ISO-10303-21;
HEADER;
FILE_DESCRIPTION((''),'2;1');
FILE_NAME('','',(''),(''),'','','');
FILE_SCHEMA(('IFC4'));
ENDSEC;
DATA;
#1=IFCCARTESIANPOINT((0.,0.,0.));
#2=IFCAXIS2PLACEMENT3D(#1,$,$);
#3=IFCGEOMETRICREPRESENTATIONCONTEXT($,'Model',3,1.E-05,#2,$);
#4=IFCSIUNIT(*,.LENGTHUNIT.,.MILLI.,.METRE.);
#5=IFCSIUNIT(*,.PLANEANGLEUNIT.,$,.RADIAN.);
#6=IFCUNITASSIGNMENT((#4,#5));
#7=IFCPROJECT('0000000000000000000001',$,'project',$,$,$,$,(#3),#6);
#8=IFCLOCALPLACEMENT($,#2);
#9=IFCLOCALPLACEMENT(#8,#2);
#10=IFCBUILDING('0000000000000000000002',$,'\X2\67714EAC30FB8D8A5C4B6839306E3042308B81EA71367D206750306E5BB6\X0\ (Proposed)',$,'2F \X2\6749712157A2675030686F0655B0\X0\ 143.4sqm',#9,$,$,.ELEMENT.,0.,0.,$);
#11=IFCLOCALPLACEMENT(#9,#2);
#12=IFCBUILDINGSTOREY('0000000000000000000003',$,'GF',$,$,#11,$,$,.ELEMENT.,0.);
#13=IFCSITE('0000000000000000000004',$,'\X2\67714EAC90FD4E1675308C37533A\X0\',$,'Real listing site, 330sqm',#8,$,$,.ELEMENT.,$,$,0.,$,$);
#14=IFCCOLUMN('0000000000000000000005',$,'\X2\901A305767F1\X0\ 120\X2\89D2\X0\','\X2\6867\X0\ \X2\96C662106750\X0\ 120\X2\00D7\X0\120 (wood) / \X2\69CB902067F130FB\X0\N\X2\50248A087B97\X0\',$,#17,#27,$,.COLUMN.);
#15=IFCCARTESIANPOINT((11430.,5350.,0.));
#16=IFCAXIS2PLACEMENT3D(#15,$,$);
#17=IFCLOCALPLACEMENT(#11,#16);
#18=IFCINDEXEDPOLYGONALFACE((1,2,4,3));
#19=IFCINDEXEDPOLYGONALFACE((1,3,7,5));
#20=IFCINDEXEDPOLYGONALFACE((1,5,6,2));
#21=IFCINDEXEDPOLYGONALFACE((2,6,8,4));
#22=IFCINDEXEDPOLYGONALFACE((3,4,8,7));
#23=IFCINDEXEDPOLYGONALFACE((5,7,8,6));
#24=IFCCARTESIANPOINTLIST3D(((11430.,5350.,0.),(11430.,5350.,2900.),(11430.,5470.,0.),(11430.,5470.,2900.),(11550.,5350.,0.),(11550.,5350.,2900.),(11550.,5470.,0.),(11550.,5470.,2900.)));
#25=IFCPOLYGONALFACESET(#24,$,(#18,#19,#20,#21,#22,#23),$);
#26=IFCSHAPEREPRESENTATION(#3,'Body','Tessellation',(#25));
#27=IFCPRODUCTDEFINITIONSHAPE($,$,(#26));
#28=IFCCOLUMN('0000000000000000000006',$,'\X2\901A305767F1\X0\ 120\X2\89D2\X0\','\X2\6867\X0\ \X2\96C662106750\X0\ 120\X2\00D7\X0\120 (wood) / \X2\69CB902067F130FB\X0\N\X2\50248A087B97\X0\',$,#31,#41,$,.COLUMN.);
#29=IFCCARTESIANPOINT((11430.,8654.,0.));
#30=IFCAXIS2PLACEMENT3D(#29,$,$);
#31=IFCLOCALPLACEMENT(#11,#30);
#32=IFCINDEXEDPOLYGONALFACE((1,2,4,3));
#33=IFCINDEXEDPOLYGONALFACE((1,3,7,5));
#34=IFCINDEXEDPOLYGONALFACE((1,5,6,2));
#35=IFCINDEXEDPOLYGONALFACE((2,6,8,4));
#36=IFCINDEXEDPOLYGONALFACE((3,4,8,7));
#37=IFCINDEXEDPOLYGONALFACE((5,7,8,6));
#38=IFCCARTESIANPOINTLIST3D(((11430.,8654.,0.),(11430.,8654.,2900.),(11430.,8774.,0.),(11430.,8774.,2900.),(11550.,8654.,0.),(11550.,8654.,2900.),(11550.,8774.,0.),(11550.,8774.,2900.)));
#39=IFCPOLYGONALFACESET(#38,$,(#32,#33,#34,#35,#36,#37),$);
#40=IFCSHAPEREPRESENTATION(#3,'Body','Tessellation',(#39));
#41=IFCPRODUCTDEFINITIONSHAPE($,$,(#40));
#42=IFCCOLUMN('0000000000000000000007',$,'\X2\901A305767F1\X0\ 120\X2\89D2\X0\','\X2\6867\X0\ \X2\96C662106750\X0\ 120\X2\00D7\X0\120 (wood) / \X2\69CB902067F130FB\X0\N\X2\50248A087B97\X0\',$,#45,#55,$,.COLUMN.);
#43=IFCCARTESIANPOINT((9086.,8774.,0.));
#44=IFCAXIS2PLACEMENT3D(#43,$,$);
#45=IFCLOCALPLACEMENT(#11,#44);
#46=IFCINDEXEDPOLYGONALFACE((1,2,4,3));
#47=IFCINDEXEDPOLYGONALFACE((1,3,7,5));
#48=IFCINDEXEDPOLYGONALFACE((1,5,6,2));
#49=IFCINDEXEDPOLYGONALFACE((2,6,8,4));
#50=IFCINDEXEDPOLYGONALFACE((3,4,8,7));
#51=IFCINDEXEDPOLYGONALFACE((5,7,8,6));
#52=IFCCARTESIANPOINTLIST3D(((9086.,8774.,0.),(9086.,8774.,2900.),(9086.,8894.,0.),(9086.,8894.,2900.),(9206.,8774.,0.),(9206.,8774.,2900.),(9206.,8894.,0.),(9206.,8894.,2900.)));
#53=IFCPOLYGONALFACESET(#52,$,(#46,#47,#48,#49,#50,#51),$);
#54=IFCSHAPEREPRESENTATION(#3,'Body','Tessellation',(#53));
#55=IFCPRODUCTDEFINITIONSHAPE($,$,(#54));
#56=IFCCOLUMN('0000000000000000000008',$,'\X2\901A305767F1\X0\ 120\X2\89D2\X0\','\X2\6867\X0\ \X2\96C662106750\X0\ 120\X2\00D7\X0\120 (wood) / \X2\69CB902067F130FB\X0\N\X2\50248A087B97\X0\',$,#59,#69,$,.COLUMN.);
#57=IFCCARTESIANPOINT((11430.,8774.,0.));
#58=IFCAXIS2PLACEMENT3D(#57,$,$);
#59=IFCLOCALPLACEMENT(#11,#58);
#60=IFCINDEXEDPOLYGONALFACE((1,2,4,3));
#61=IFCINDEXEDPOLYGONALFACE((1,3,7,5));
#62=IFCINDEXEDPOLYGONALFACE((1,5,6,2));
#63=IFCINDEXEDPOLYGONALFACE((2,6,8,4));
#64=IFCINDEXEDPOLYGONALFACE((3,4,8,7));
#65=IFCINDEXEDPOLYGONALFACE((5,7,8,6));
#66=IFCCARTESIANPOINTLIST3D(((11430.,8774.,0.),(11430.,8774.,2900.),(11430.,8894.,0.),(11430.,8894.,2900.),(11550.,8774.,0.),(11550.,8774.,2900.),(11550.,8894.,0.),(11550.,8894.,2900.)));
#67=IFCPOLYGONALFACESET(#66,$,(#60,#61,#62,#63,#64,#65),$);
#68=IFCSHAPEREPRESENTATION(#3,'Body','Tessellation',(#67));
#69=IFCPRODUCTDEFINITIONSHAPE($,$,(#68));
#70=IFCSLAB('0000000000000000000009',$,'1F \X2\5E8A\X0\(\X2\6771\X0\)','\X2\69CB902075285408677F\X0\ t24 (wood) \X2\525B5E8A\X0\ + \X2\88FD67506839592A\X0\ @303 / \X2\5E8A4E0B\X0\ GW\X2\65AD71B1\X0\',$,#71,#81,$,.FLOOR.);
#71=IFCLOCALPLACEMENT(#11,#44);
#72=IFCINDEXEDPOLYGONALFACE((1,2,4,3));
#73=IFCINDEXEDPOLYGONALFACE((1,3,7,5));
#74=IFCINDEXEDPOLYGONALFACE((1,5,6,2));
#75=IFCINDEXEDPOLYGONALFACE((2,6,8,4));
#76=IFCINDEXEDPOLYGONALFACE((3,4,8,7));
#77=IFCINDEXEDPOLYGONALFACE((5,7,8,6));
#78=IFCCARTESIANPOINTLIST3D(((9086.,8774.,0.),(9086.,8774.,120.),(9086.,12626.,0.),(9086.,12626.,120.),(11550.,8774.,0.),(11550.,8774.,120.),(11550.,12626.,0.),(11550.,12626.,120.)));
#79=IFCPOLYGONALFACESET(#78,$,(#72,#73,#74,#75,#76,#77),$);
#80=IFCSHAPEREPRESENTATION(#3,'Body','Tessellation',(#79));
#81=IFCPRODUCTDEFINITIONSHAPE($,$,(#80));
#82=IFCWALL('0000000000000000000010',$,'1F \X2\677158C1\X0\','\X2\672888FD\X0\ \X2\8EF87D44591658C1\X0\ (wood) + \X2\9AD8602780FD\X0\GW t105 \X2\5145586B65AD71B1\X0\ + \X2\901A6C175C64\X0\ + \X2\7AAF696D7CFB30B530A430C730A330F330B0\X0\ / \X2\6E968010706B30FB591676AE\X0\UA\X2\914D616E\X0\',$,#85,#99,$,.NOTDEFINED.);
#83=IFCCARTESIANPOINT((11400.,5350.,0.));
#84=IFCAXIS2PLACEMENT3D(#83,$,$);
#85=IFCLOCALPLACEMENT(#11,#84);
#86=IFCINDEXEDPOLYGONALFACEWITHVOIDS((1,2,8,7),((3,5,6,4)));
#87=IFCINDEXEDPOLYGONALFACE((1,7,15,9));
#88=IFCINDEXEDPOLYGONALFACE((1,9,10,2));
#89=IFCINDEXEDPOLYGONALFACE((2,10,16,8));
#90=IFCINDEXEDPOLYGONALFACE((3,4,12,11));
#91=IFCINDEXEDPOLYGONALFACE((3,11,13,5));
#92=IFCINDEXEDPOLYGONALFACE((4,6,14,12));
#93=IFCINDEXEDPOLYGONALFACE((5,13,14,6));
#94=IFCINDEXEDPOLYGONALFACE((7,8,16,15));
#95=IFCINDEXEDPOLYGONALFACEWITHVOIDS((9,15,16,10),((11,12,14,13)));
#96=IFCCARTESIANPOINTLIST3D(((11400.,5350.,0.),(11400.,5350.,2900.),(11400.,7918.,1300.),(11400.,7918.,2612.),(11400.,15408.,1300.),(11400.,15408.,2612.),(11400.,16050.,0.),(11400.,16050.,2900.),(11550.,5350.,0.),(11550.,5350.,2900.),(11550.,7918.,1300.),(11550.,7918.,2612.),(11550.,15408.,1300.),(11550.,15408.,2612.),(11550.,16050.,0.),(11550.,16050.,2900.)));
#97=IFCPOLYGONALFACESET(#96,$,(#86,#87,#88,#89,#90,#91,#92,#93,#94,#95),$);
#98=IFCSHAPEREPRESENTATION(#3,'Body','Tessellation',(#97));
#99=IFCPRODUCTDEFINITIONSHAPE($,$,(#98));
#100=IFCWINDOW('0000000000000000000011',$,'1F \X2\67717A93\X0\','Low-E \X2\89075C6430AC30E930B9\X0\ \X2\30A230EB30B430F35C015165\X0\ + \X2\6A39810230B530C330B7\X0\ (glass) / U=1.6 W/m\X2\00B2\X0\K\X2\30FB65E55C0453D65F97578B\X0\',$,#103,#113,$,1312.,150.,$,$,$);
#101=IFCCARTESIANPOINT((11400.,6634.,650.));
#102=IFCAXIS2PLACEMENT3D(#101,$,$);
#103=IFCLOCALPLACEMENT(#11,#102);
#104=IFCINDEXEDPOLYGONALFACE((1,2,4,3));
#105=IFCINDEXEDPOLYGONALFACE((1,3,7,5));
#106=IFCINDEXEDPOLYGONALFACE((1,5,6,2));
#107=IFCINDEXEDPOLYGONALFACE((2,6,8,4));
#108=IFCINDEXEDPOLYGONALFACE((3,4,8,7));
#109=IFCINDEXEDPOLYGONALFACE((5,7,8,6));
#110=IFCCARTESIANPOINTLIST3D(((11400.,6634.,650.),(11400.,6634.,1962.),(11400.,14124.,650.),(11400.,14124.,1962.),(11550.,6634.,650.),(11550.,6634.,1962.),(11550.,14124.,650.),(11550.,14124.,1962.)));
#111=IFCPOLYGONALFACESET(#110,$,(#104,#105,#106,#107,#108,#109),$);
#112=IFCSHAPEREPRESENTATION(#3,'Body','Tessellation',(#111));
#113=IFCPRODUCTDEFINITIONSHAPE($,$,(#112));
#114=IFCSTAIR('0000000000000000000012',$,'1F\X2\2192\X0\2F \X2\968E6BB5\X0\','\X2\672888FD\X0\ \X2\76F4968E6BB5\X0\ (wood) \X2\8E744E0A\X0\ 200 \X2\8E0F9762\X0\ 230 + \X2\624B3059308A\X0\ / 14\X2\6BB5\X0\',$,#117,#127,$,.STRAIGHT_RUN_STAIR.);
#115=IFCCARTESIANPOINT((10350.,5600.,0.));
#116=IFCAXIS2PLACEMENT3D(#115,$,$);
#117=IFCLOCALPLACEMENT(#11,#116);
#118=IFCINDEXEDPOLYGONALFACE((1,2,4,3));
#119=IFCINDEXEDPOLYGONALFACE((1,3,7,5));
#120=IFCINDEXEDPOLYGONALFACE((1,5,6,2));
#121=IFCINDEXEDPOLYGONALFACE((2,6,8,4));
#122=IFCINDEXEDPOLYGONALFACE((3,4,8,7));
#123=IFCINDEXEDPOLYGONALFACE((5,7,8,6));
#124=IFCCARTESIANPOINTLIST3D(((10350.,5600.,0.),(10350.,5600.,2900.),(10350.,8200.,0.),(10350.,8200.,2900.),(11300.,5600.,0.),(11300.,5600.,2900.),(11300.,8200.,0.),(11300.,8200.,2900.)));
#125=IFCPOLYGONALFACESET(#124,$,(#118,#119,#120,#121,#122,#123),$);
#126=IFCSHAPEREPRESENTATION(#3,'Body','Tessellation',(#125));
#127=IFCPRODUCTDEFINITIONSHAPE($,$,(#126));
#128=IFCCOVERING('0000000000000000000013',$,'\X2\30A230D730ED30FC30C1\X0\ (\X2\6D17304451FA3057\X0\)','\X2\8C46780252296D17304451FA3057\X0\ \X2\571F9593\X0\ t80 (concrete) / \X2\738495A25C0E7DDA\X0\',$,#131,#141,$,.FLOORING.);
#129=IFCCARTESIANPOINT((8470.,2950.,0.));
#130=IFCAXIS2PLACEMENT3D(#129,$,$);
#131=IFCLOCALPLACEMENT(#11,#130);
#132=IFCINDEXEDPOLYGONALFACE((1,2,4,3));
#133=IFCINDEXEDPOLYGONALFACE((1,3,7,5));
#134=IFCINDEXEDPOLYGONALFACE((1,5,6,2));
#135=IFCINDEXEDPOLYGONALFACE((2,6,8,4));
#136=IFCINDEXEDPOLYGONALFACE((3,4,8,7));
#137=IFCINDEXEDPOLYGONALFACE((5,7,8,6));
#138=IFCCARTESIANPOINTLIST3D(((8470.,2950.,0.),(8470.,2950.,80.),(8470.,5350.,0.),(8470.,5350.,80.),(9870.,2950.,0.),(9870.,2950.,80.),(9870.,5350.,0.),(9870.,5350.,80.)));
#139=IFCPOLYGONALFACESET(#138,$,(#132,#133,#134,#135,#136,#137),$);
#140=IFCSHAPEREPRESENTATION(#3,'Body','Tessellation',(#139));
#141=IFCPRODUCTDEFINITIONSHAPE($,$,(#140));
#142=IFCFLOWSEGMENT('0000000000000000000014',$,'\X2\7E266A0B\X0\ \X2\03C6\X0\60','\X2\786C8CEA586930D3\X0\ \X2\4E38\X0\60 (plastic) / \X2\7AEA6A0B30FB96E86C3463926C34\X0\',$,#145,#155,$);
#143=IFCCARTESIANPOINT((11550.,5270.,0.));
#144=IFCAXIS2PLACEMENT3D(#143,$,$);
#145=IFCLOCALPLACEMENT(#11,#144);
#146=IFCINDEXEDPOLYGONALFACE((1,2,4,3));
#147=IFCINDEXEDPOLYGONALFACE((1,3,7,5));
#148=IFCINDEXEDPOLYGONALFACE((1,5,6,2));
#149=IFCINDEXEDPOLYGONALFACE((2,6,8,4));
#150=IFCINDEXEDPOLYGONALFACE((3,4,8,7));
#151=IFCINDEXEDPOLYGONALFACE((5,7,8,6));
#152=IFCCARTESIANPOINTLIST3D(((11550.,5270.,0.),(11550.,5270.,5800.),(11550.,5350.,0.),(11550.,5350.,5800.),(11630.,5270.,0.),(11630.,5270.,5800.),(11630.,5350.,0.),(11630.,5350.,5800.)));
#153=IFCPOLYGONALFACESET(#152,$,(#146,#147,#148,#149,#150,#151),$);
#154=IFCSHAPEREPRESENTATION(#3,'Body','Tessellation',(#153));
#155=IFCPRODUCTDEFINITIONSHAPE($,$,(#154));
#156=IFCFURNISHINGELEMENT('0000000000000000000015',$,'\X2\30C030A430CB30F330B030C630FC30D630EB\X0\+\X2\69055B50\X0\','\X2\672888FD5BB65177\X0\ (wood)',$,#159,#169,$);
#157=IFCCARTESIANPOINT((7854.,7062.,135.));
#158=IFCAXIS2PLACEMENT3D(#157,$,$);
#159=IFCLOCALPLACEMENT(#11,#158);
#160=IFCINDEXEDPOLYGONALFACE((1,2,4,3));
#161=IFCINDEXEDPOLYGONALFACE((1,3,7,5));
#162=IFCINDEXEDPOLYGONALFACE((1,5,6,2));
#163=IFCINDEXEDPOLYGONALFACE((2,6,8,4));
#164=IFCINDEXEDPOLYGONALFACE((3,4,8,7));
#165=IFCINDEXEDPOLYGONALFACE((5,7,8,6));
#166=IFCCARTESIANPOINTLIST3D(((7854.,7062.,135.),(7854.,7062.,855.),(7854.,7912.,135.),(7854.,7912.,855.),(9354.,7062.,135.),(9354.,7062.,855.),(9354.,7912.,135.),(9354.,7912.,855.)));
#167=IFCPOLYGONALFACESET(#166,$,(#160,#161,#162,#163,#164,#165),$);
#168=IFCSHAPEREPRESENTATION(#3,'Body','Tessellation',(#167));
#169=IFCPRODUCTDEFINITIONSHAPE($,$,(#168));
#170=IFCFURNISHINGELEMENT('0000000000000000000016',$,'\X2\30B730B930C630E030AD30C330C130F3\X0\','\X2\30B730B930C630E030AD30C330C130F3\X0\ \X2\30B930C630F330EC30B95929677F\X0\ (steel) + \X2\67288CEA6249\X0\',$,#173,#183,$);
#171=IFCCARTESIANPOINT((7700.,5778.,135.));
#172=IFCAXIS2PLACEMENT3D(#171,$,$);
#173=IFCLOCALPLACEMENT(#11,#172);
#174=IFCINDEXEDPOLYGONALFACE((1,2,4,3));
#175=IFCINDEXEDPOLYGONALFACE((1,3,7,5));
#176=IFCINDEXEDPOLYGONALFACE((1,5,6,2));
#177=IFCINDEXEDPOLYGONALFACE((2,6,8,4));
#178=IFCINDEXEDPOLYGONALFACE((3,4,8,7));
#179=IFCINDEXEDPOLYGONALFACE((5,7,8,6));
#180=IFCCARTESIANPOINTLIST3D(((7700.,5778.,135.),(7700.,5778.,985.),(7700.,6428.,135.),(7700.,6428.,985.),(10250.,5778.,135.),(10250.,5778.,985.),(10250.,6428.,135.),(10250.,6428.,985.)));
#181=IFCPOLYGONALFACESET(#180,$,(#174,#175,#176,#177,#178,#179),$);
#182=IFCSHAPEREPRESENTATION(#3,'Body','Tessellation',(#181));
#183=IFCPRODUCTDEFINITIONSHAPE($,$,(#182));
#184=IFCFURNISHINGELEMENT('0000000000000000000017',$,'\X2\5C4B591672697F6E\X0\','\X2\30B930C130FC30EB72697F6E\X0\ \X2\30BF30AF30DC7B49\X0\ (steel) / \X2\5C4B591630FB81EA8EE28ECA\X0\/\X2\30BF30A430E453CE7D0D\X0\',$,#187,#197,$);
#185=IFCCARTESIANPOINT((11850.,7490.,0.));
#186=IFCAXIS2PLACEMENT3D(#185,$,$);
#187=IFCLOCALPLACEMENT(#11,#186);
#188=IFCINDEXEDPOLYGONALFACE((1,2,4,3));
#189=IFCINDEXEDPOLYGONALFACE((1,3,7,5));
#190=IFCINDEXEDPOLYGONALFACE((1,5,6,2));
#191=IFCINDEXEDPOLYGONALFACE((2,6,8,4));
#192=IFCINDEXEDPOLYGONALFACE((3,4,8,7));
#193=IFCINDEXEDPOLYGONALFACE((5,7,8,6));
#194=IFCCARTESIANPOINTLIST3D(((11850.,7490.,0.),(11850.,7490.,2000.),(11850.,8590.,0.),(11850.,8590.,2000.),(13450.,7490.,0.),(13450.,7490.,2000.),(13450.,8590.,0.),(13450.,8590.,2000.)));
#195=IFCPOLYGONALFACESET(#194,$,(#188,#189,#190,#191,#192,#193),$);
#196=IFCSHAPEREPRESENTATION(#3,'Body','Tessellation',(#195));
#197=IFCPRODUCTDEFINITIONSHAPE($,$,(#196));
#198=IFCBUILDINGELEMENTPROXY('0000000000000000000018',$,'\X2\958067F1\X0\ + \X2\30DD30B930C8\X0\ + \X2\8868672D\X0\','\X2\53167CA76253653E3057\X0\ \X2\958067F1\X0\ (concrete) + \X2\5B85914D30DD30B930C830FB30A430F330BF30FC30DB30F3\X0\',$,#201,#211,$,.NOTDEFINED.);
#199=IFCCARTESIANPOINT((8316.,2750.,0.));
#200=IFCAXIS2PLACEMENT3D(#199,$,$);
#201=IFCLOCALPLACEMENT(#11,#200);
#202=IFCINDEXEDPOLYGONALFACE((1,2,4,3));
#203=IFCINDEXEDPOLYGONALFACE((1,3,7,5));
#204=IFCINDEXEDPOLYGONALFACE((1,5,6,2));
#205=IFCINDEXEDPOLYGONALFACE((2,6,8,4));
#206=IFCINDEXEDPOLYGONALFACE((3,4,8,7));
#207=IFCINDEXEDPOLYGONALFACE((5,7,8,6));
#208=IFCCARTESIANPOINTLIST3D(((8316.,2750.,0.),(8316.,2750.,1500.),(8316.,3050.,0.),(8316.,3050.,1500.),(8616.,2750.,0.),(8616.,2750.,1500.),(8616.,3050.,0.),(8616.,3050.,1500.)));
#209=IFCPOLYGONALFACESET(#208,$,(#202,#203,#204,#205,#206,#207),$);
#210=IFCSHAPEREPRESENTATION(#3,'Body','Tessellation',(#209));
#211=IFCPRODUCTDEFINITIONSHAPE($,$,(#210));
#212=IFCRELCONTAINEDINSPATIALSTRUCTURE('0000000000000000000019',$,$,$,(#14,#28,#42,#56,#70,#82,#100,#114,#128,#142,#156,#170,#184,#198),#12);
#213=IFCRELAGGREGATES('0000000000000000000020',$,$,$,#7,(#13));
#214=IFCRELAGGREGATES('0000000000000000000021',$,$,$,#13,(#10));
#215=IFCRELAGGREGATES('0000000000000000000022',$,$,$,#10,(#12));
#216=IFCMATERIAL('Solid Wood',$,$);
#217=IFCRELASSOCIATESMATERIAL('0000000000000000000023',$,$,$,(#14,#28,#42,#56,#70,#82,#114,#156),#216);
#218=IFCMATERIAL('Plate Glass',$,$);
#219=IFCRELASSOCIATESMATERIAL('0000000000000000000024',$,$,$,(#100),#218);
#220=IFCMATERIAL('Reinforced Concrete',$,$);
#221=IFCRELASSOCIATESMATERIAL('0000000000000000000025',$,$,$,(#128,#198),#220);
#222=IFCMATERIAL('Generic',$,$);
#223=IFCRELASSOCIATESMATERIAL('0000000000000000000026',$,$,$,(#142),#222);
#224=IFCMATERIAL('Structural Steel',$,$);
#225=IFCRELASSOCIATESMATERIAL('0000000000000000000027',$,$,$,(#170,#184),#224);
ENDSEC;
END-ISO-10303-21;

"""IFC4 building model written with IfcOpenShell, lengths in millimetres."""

from ifc_helpers import new_model, si_unit, frame, frame_2d, origin, place, context, project, spatial, rectangle, extrude, material, element, fill, save


model = new_model("IFC4")

# Units and contexts
model_context = context("Model", 3, precision=1e-05, world=origin())
ifc_project = project(units=[si_unit("LENGTHUNIT", "METRE", prefix="MILLI"), si_unit("PLANEANGLEUNIT", "RADIAN")], contexts=[model_context])

# Site, building, storey
site_placement = place(None, origin())
site = spatial("IfcSite", under=ifc_project, at=site_placement, Name="東京都世田谷区", ObjectType="Real listing site, 330sqm", CompositionType="ELEMENT", RefElevation=0.0)
building_placement = place(site_placement, origin())
building = spatial("IfcBuilding", under=site, at=building_placement, Name="東京・越屋根のある自然素材の家 (Proposed)", ObjectType="2F 杉無垢材と漆喰 143.4sqm", CompositionType="ELEMENT", ElevationOfRefHeight=0.0, ElevationOfTerrain=0.0)
storey_placement = place(building_placement, origin())
storey = spatial("IfcBuildingStorey", under=building, at=storey_placement, Name="GF", CompositionType="ELEMENT", Elevation=0.0)

# Columns
ifc_material_1 = material(Name="Solid Wood")
column_1_placement = place(storey_placement, frame((11430.0, 5350.0, 0.0)))
element("IfcColumn", 1, at=column_1_placement, inside=storey, material=ifc_material_1, Name="通し柱 120角", Description="桧 集成材 120×120 (wood) / 構造柱・N値計算", PredefinedType="COLUMN", context=model_context, shape_type="SweptSolid", body=[
    extrude(rectangle(XDim=120.0, YDim=120.0, at=frame_2d((60.0, 60.0))), frame((11430.0, 5350.0, 0.0)), (0.0, 0.0, 1.0), 2900.0),
])
column_2_placement = place(storey_placement, frame((11430.0, 8654.0, 0.0)))
element("IfcColumn", 2, at=column_2_placement, inside=storey, material=ifc_material_1, Name="通し柱 120角", Description="桧 集成材 120×120 (wood) / 構造柱・N値計算", PredefinedType="COLUMN", context=model_context, shape_type="SweptSolid", body=[
    extrude(rectangle(XDim=120.0, YDim=120.0, at=frame_2d((60.0, 60.0))), frame((11430.0, 8654.0, 0.0)), (0.0, 0.0, 1.0), 2900.0),
])
column_3_placement = place(storey_placement, frame((9086.0, 8774.0, 0.0)))
element("IfcColumn", 3, at=column_3_placement, inside=storey, material=ifc_material_1, Name="通し柱 120角", Description="桧 集成材 120×120 (wood) / 構造柱・N値計算", PredefinedType="COLUMN", context=model_context, shape_type="SweptSolid", body=[
    extrude(rectangle(XDim=120.0, YDim=120.0, at=frame_2d((60.0, 60.0))), frame((9086.0, 8774.0, 0.0)), (0.0, 0.0, 1.0), 2900.0),
])
column_4_placement = place(storey_placement, frame((11430.0, 8774.0, 0.0)))
element("IfcColumn", 4, at=column_4_placement, inside=storey, material=ifc_material_1, Name="通し柱 120角", Description="桧 集成材 120×120 (wood) / 構造柱・N値計算", PredefinedType="COLUMN", context=model_context, shape_type="SweptSolid", body=[
    extrude(rectangle(XDim=120.0, YDim=120.0, at=frame_2d((60.0, 60.0))), frame((11430.0, 8774.0, 0.0)), (0.0, 0.0, 1.0), 2900.0),
])

# Slab
slab_placement = place(storey_placement, frame((9086.0, 8774.0, 0.0)))
element("IfcSlab", 5, at=slab_placement, inside=storey, material=ifc_material_1, Name="1F 床(東)", Description="構造用合板 t24 (wood) 剛床 + 製材根太 @303 / 床下 GW断熱", PredefinedType="FLOOR", context=model_context, shape_type="SweptSolid", body=[
    extrude(rectangle(XDim=2464.0, YDim=3852.0, at=frame_2d((1232.0, 1926.0))), frame((9086.0, 8774.0, 0.0)), (0.0, 0.0, 1.0), 120.0),
])

# Wall, opening, window
wall_1_placement = place(storey_placement, frame((11400.0, 5350.0, 0.0)))
wall_1 = element("IfcWall", 6, at=wall_1_placement, inside=storey, material=ifc_material_1, Name="1F 東壁", Description="木製 軸組外壁 (wood) + 高性能GW t105 充填断熱 + 通気層 + 窯業系サイディング / 準耐火・外皮UA配慮", PredefinedType="NOTDEFINED", context=model_context, shape_type="SweptSolid", body=[
    extrude(rectangle(XDim=150.0, YDim=10700.0, at=frame_2d((75.0, 5350.0))), frame((11400.0, 5350.0, 0.0)), (0.0, 0.0, 1.0), 2900.0),
])
opening_placement = place(storey_placement, frame((11400.0, 6634.0, 650.0)))
opening = element("IfcOpeningElement", 7, at=opening_placement, cuts=wall_1, PredefinedType="NOTDEFINED", context=model_context, shape_type="SweptSolid", body=[
    extrude(rectangle(XDim=150.0, YDim=7490.0, at=frame_2d((75.0, 3745.0))), frame((11400.0, 6634.0, 650.0)), (0.0, 0.0, 1.0), 1312.0),
])
ifc_material_2 = material(Name="Plate Glass")
window_placement = place(storey_placement, frame((11400.0, 6634.0, 650.0)))
window = element("IfcWindow", 8, at=window_placement, inside=storey, material=ifc_material_2, Name="1F 東窓", Description="Low-E 複層ガラス アルゴン封入 + 樹脂サッシ (glass) / U=1.6 W/m²K・日射取得型", OverallHeight=1312.0, OverallWidth=150.0, context=model_context, shape_type="SweptSolid", body=[
    extrude(rectangle(XDim=150.0, YDim=7490.0, at=frame_2d((75.0, 3745.0))), frame((11400.0, 6634.0, 650.0)), (0.0, 0.0, 1.0), 1312.0),
])
fill(opening, window)

# Stair
stair_placement = place(storey_placement, frame((10350.0, 5600.0, 0.0)))
element("IfcStair", 9, at=stair_placement, inside=storey, material=ifc_material_1, Name="1F→2F 階段", Description="木製 直階段 (wood) 蹴上 200 踏面 230 + 手すり / 14段", PredefinedType="STRAIGHT_RUN_STAIR", context=model_context, shape_type="SweptSolid", body=[
    extrude(rectangle(XDim=950.0, YDim=2600.0, at=frame_2d((475.0, 1300.0))), frame((10350.0, 5600.0, 0.0)), (0.0, 0.0, 1.0), 2900.0),
])

# Covering
ifc_material_3 = material(Name="Reinforced Concrete")
covering_placement = place(storey_placement, frame((8470.0, 2950.0, 0.0)))
element("IfcCovering", 10, at=covering_placement, inside=storey, material=ifc_material_3, Name="アプローチ (洗い出し)", Description="豆砂利洗い出し 土間 t80 (concrete) / 玄関導線", PredefinedType="FLOORING", context=model_context, shape_type="SweptSolid", body=[
    extrude(rectangle(XDim=1400.0, YDim=2400.0, at=frame_2d((700.0, 1200.0))), frame((8470.0, 2950.0, 0.0)), (0.0, 0.0, 1.0), 80.0),
])

# Flow segment
ifc_material_4 = material(Name="Generic")
flow_segment_placement = place(storey_placement, frame((11550.0, 5270.0, 0.0)))
element("IfcFlowSegment", 11, at=flow_segment_placement, inside=storey, material=ifc_material_4, Name="縦樋 φ60", Description="硬質塩ビ 丸60 (plastic) / 竪樋・雨水排水", context=model_context, shape_type="SweptSolid", body=[
    extrude(rectangle(XDim=80.0, YDim=80.0, at=frame_2d((40.0, 40.0))), frame((11550.0, 5270.0, 0.0)), (0.0, 0.0, 1.0), 5800.0),
])

# Furnishing elements
furnishing_1_placement = place(storey_placement, frame((7854.0, 7062.0, 135.0)))
element("IfcFurnishingElement", 12, at=furnishing_1_placement, inside=storey, material=ifc_material_1, Name="ダイニングテーブル+椅子", Description="木製家具 (wood)", context=model_context, shape_type="SweptSolid", body=[
    extrude(rectangle(XDim=1500.0, YDim=850.0, at=frame_2d((750.0, 425.0))), frame((7854.0, 7062.0, 135.0)), (0.0, 0.0, 1.0), 720.0),
])
ifc_material_5 = material(Name="Structural Steel")
furnishing_2_placement = place(storey_placement, frame((7700.0, 5778.0, 135.0)))
element("IfcFurnishingElement", 13, at=furnishing_2_placement, inside=storey, material=ifc_material_5, Name="システムキッチン", Description="システムキッチン ステンレス天板 (steel) + 木質扉", context=model_context, shape_type="SweptSolid", body=[
    extrude(rectangle(XDim=2550.0, YDim=650.0, at=frame_2d((1275.0, 325.0))), frame((7700.0, 5778.0, 135.0)), (0.0, 0.0, 1.0), 850.0),
])
furnishing_3_placement = place(storey_placement, frame((11850.0, 7490.0, 0.0)))
element("IfcFurnishingElement", 14, at=furnishing_3_placement, inside=storey, material=ifc_material_5, Name="屋外物置", Description="スチール物置 タクボ等 (steel) / 屋外・自転車/タイヤ収納", context=model_context, shape_type="SweptSolid", body=[
    extrude(rectangle(XDim=1600.0, YDim=1100.0, at=frame_2d((800.0, 550.0))), frame((11850.0, 7490.0, 0.0)), (0.0, 0.0, 1.0), 2000.0),
])

# Building element proxy
proxy_placement = place(storey_placement, frame((8316.0, 2750.0, 0.0)))
element("IfcBuildingElementProxy", 15, at=proxy_placement, inside=storey, material=ifc_material_3, Name="門柱 + ポスト + 表札", Description="化粧打放し 門柱 (concrete) + 宅配ポスト・インターホン", PredefinedType="NOTDEFINED", context=model_context, shape_type="SweptSolid", body=[
    extrude(rectangle(XDim=300.0, YDim=300.0, at=frame_2d((150.0, 150.0))), frame((8316.0, 2750.0, 0.0)), (0.0, 0.0, 1.0), 1500.0),
])

save(model, "model.ifc")
